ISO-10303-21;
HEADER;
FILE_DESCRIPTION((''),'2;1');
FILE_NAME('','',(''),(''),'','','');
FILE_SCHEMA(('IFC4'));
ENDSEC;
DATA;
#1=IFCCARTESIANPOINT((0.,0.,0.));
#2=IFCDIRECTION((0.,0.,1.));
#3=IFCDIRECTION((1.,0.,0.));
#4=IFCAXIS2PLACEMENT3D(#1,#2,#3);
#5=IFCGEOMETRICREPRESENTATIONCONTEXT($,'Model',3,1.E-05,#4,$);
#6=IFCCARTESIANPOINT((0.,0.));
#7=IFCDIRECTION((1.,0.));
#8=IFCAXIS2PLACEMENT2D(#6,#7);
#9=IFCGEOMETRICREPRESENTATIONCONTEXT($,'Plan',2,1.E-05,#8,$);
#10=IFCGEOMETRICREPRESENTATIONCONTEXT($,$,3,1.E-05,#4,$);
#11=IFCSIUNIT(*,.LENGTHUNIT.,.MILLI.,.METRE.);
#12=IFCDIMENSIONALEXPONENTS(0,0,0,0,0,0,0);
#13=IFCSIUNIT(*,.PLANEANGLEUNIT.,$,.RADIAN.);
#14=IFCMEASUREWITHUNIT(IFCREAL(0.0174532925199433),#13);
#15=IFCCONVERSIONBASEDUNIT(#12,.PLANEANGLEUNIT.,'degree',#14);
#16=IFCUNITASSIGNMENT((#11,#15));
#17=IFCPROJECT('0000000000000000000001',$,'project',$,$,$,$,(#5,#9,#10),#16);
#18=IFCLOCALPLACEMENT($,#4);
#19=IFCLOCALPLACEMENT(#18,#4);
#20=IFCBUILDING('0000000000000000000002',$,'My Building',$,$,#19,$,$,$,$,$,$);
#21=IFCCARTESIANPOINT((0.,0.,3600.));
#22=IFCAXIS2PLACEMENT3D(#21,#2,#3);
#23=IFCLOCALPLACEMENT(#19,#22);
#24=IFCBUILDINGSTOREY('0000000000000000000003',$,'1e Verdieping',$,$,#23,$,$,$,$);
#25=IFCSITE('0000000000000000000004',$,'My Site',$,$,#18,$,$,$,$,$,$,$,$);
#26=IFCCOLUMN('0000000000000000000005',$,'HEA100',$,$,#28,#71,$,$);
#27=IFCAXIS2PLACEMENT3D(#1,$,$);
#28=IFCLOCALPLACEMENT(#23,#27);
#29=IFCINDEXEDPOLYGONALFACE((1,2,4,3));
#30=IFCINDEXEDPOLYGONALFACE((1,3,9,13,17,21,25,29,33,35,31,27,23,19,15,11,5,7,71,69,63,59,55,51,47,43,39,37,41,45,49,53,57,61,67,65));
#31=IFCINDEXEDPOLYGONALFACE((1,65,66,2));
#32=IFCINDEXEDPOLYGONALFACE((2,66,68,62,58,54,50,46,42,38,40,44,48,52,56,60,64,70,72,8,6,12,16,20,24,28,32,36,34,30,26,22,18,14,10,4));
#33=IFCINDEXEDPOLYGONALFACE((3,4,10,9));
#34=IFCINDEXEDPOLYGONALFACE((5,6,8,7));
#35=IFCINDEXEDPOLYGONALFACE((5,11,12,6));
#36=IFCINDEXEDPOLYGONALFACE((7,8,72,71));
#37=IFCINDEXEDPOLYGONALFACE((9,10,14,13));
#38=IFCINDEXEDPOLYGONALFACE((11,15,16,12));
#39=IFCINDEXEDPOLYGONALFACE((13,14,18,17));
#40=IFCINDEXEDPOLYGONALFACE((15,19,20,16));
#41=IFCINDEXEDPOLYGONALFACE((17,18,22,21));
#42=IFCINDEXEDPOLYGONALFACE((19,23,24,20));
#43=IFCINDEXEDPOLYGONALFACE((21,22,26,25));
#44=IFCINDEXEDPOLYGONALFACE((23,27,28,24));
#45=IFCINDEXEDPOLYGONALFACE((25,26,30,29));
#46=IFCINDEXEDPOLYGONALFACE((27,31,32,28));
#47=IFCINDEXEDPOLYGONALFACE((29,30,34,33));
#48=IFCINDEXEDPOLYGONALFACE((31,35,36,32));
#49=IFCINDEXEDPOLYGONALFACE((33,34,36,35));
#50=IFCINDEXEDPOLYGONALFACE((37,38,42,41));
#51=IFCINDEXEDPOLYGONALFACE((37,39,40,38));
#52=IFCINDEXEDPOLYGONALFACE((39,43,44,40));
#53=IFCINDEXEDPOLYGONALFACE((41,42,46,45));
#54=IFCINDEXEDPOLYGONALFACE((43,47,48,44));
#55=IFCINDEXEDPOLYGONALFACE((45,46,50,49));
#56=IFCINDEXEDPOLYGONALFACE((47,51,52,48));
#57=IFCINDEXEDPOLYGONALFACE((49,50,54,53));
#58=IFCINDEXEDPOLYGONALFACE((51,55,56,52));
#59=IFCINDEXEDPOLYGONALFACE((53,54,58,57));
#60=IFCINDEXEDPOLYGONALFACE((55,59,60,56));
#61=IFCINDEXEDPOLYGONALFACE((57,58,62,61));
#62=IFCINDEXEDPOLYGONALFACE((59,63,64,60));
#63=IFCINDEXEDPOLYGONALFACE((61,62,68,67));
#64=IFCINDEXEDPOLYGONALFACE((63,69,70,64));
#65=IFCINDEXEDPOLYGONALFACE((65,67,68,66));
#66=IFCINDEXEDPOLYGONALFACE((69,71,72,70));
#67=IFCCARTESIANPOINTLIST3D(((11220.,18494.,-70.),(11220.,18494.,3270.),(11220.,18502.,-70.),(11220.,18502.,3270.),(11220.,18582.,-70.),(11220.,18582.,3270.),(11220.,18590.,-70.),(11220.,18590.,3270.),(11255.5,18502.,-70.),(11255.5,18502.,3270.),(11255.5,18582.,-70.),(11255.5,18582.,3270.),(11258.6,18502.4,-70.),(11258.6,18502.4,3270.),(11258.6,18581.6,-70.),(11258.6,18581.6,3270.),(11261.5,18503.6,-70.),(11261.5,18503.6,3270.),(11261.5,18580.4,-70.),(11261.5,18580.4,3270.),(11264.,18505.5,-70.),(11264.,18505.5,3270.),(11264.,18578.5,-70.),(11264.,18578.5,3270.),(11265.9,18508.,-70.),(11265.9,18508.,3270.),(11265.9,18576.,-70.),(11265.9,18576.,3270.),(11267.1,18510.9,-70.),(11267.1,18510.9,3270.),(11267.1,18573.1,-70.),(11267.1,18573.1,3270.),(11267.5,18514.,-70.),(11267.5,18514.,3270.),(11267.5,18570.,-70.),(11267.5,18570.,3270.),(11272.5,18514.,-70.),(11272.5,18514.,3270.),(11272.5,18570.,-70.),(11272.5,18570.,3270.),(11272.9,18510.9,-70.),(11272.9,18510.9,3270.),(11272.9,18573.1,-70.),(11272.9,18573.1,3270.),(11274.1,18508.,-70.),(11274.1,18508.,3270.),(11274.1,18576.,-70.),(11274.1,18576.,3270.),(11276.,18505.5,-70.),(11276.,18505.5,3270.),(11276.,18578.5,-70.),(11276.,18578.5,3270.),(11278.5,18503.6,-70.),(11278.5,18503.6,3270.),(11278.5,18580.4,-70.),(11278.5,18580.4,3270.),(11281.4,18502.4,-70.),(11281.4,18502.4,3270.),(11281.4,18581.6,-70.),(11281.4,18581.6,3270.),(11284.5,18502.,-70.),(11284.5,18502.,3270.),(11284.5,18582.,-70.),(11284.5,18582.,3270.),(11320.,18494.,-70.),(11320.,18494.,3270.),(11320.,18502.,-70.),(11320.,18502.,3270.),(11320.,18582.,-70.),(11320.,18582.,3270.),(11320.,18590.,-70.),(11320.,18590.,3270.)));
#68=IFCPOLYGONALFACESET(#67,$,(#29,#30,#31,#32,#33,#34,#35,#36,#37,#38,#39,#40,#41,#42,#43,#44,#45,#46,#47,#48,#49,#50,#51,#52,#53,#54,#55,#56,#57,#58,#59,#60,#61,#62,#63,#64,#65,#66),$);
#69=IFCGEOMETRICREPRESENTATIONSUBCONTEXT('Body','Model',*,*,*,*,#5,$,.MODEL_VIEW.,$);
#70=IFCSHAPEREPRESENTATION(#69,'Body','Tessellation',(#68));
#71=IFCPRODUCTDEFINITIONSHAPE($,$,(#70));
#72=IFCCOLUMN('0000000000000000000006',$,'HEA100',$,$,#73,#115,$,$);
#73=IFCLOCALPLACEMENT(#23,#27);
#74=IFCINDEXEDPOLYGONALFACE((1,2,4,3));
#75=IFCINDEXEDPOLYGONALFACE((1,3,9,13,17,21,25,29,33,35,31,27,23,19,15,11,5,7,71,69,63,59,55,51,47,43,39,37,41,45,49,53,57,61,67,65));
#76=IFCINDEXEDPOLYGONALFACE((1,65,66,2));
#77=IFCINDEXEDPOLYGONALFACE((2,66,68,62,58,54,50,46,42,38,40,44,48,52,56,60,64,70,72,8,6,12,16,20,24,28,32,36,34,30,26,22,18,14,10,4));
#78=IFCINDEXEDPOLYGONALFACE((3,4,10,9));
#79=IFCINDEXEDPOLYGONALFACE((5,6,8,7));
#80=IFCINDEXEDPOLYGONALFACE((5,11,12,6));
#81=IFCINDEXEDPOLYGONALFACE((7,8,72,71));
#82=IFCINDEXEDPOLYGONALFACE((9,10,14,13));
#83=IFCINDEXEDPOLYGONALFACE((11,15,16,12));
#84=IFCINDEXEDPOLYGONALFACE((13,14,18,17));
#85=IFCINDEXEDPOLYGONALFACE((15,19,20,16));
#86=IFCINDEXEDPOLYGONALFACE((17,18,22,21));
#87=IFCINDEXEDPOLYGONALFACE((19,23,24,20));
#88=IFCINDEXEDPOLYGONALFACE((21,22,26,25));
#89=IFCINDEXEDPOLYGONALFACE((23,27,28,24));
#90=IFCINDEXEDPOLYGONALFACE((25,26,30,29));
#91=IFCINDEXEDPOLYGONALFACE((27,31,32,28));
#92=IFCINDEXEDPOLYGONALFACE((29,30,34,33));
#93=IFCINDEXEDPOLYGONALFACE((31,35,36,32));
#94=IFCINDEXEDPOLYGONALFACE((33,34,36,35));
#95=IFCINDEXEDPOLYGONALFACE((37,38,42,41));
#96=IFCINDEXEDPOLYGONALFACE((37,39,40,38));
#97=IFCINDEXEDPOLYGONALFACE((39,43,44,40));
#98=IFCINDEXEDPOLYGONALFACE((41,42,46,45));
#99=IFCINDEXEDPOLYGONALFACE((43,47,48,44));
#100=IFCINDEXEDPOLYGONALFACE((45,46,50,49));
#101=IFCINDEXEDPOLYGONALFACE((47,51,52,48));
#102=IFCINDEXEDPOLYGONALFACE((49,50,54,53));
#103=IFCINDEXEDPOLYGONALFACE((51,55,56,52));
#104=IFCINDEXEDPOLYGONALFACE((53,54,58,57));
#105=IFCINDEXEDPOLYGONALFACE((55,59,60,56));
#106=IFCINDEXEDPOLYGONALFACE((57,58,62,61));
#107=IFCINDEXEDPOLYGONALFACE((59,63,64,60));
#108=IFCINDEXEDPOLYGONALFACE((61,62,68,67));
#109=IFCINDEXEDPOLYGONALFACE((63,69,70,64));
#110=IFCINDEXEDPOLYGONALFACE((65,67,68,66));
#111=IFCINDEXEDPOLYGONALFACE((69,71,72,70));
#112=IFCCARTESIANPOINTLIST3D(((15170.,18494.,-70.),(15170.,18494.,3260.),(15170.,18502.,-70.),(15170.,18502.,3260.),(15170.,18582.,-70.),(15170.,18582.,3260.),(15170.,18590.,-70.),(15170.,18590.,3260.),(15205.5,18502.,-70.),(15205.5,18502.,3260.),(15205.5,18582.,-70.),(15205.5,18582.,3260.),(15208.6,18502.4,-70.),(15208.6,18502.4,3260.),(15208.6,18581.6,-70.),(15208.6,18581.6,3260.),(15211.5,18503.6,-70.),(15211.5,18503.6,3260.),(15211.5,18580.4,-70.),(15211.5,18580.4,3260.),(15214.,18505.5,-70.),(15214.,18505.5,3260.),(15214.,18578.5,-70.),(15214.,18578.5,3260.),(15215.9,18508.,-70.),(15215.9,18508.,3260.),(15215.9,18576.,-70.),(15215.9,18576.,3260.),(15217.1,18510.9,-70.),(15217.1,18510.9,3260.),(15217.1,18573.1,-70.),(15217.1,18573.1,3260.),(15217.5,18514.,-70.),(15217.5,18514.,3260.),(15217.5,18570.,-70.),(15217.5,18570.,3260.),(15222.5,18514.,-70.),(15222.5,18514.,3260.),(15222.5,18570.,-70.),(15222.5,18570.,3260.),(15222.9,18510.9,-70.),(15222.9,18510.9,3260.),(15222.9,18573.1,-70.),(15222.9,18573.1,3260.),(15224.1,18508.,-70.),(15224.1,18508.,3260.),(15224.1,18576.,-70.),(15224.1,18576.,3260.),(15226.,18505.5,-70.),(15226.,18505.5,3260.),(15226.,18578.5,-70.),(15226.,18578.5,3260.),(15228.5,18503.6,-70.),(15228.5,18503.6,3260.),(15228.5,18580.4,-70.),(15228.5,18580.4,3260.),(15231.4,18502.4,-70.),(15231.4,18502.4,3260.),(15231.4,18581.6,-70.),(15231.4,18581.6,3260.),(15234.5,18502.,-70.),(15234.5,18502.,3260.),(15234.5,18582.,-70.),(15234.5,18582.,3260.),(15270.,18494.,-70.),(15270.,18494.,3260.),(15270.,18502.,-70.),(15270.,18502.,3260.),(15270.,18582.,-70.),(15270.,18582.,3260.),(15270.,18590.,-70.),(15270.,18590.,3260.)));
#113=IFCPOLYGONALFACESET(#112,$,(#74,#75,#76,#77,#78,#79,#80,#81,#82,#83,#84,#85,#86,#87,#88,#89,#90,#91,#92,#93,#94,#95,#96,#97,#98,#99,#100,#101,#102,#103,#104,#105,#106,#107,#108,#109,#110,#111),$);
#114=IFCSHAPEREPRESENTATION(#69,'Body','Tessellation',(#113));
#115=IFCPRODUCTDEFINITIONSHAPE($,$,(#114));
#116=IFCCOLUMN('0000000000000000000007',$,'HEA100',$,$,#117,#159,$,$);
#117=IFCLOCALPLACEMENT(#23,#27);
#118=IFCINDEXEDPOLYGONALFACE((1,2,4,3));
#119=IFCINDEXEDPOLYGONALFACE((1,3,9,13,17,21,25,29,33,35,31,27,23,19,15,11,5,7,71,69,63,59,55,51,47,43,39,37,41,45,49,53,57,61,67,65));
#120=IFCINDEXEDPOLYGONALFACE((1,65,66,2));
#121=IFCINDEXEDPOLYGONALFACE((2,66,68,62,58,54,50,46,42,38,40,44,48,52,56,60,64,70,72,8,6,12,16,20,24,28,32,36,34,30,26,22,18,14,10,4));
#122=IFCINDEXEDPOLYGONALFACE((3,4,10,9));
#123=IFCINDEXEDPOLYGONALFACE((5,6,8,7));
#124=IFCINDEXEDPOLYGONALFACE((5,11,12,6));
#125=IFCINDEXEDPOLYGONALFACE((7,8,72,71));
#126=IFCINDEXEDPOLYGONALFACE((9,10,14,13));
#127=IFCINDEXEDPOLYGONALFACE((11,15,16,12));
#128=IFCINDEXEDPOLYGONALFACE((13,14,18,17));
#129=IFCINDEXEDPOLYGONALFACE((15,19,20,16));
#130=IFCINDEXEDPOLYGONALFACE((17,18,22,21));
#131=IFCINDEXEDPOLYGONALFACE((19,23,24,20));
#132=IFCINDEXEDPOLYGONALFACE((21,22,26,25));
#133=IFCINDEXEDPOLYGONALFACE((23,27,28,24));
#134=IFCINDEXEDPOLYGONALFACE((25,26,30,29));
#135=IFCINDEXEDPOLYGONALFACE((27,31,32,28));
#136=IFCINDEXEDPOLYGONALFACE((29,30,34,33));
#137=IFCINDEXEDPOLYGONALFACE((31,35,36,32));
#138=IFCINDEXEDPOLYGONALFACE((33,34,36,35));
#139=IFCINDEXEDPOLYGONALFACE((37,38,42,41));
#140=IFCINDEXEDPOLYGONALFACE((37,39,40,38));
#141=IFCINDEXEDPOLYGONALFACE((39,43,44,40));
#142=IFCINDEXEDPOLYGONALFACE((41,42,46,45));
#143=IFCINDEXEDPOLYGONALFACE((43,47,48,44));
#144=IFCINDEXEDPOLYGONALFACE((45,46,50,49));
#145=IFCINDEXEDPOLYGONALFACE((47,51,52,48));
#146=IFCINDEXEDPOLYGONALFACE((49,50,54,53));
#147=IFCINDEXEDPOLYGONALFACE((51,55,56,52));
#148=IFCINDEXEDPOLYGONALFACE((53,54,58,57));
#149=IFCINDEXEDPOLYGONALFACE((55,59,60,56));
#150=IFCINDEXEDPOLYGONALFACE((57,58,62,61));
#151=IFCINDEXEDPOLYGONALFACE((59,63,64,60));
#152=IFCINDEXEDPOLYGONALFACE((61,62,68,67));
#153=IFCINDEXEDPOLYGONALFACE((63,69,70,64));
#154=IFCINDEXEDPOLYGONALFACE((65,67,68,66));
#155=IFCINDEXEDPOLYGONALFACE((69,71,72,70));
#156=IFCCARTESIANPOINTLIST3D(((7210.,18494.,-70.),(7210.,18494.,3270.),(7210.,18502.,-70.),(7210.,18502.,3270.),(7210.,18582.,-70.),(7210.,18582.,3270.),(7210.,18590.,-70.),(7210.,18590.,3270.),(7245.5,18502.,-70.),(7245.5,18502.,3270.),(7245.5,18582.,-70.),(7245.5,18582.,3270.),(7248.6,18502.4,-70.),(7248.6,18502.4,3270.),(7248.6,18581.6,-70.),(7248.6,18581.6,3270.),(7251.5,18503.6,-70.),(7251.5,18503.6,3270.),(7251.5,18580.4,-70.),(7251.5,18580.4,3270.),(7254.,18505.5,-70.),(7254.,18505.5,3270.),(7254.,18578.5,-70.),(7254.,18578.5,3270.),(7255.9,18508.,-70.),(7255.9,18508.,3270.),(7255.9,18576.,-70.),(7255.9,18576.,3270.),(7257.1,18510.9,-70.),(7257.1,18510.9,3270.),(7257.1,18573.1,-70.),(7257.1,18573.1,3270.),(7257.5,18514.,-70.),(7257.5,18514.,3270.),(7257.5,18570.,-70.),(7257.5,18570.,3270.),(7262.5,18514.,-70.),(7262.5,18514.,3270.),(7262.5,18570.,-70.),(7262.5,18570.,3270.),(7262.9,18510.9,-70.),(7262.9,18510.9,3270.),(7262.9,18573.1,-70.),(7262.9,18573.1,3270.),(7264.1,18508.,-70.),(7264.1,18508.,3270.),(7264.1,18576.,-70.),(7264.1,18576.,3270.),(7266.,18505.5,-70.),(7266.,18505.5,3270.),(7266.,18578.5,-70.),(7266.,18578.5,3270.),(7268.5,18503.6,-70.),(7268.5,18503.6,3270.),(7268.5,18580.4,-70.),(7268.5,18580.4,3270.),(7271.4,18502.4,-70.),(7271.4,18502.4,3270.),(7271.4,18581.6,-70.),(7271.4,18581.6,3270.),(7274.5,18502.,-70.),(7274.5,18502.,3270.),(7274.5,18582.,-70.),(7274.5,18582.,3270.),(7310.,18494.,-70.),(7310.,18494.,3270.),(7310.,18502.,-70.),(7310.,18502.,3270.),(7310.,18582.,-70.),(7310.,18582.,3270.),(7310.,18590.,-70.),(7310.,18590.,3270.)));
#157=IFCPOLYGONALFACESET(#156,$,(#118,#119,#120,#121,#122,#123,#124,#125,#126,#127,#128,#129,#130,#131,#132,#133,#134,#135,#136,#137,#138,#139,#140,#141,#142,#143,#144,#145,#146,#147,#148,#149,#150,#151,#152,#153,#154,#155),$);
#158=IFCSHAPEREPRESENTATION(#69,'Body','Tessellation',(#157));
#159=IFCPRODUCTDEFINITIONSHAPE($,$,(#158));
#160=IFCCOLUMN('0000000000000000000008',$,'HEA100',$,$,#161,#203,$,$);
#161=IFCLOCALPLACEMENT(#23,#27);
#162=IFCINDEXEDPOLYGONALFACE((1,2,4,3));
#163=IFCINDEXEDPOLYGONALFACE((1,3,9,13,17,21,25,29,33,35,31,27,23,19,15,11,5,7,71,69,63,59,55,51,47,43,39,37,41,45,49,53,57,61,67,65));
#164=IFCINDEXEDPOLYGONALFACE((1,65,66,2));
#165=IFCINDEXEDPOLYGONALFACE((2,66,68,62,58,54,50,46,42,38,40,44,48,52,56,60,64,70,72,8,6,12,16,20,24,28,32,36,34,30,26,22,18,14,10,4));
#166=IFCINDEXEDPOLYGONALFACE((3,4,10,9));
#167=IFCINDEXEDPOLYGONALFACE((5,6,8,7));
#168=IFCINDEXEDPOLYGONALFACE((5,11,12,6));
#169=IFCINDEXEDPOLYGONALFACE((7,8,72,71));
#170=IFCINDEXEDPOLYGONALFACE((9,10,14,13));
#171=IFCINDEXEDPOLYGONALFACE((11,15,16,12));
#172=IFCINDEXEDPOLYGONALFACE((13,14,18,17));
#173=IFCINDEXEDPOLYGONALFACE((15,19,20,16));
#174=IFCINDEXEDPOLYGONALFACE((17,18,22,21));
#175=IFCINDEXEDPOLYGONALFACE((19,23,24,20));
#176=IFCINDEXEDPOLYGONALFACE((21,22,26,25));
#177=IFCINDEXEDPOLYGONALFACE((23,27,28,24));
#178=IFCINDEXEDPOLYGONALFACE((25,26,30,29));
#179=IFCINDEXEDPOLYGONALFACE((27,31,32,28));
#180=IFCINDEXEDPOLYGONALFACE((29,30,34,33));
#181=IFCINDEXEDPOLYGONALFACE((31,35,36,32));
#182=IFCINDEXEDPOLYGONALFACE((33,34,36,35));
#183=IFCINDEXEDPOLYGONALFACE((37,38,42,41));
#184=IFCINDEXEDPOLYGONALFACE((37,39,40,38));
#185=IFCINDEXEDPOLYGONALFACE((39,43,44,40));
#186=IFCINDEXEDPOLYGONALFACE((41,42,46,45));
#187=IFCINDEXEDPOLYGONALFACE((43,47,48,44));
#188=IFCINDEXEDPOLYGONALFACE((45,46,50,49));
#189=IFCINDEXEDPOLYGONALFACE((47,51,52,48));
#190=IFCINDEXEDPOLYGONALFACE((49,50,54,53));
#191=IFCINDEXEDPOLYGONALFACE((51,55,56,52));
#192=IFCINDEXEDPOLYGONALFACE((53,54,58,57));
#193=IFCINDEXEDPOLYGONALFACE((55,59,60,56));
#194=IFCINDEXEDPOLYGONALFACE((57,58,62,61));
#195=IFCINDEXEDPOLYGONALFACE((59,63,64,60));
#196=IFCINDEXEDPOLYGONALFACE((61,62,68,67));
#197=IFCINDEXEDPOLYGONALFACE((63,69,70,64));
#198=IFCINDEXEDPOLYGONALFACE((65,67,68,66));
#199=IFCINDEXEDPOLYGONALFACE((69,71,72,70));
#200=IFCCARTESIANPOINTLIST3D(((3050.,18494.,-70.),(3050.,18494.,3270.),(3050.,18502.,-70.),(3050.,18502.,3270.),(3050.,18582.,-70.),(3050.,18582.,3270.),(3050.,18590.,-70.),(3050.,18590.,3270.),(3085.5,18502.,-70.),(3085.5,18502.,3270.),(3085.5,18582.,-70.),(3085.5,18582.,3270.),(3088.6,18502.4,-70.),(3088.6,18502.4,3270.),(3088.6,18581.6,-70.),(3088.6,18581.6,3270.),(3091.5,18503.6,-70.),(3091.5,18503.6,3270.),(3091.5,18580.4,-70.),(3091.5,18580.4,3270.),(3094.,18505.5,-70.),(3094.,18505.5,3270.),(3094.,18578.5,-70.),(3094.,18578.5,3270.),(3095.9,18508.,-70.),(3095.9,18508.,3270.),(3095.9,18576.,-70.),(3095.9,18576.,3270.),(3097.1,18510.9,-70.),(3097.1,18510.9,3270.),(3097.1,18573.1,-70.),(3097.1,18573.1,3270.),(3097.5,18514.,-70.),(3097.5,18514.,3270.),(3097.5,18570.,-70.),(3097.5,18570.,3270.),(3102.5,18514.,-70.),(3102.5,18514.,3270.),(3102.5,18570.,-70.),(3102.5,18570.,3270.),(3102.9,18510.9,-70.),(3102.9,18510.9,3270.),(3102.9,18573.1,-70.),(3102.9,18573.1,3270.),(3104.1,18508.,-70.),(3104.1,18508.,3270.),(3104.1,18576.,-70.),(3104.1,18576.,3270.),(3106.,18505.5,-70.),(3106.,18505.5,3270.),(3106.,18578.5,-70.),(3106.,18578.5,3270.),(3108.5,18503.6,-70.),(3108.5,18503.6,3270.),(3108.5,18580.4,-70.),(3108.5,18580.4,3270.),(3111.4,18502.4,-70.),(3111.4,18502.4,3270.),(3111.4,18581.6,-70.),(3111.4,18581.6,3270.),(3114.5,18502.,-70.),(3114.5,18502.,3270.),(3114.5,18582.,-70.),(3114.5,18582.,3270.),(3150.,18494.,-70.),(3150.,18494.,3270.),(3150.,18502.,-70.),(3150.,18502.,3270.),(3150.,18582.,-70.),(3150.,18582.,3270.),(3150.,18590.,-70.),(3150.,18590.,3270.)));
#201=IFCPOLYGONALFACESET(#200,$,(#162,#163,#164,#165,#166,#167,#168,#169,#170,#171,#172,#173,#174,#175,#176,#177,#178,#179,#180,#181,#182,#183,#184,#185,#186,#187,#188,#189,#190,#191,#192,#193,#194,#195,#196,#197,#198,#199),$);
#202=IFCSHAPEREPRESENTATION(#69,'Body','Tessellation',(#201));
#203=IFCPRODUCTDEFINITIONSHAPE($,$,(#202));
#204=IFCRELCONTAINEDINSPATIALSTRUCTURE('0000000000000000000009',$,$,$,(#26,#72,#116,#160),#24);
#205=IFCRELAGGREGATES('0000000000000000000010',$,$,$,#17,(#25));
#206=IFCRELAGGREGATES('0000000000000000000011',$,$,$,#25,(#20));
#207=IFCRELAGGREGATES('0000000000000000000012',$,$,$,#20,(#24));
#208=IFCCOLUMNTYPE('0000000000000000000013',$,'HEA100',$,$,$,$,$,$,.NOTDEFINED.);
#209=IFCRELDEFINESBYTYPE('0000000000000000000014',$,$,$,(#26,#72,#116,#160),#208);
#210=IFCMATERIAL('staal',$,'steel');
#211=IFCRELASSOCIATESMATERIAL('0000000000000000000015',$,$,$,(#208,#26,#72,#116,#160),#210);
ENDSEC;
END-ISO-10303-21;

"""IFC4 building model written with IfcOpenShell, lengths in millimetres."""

from ifc_helpers import new_model, entity, si_unit, converted_unit, frame, origin_with_axes, origin_2d_with_axis, place, context, subcontext, project, spatial, i_section, extrude, material, material_profile, profile_set, profile_usage, type_object, element, save


model = new_model("IFC4")

# Units and contexts
model_context = context("Model", 3, precision=1e-05, world=origin_with_axes())
plan_context = context("Plan", 2, precision=1e-05, world=origin_2d_with_axis())
context_of_model = context(None, 3, precision=1e-05, world=origin_with_axes())
body_context = subcontext(model_context, "Body", "Model", "MODEL_VIEW")
ifc_project = project(units=[si_unit("LENGTHUNIT", "METRE", prefix="MILLI"), converted_unit("PLANEANGLEUNIT", "degree", entity("IfcReal", 0.0174532925199433), si_unit("PLANEANGLEUNIT", "RADIAN"), dimensions=[0, 0, 0, 0, 0, 0, 0])], contexts=[model_context, plan_context, context_of_model])

# Site, building, storey
site_placement = place(None, origin_with_axes())
site = spatial("IfcSite", under=ifc_project, at=site_placement, Name="My Site")
building_placement = place(site_placement, origin_with_axes())
building = spatial("IfcBuilding", under=site, at=building_placement, Name="My Building")
storey_placement = place(building_placement, frame((0.0, 0.0, 3600.0), z_axis=(0.0, 0.0, 1.0), x_axis=(1.0, 0.0, 0.0)))
storey = spatial("IfcBuildingStorey", under=building, at=storey_placement, Name="1e Verdieping")

# Columns
ifc_material_1 = material(Name="staal", Category="steel")
ifc_material_profile_1 = material_profile(ifc_material_1, i_section(OverallWidth=100.0, OverallDepth=96.0, WebThickness=5.0, FlangeThickness=8.0, FilletRadius=12.0))
ifc_profile_set_1 = profile_set([ifc_material_profile_1], Name="HEA100")
column_type_1 = type_object("IfcColumnType", Name="HEA100", PredefinedType="NOTDEFINED", material=ifc_profile_set_1)
ifc_profile_usage_1 = profile_usage(ifc_profile_set_1)
column_1_placement = place(storey_placement, frame((11270.0, 18542.0, -70.0), z_axis=(0.0, 0.0, 1.0), x_axis=(1.0, 0.0, 0.0)))
element("IfcColumn", 1, at=column_1_placement, inside=storey, type_object=column_type_1, material=ifc_profile_usage_1, Name="HEA100", context=body_context, shape_type="SweptSolid", body=[
    extrude(i_section(OverallWidth=100.0, OverallDepth=96.0, WebThickness=5.0, FlangeThickness=8.0, FilletRadius=12.0), origin_with_axes(), (0.0, 0.0, 1.0), 3340.0),
])
ifc_profile_usage_2 = profile_usage(ifc_profile_set_1)
column_2_placement = place(storey_placement, frame((15220.0, 18542.0, -70.0), z_axis=(0.0, 0.0, 1.0), x_axis=(1.0, 0.0, 0.0)))
element("IfcColumn", 2, at=column_2_placement, inside=storey, type_object=column_type_1, material=ifc_profile_usage_2, Name="HEA100", context=body_context, shape_type="SweptSolid", body=[
    extrude(i_section(OverallWidth=100.0, OverallDepth=96.0, WebThickness=5.0, FlangeThickness=8.0, FilletRadius=12.0), origin_with_axes(), (0.0, 0.0, 1.0), 3330.0),
])
ifc_profile_usage_3 = profile_usage(ifc_profile_set_1)
column_3_placement = place(storey_placement, frame((7260.0, 18542.0, -70.0), z_axis=(0.0, 0.0, 1.0), x_axis=(1.0, 0.0, 0.0)))
element("IfcColumn", 3, at=column_3_placement, inside=storey, type_object=column_type_1, material=ifc_profile_usage_3, Name="HEA100", context=body_context, shape_type="SweptSolid", body=[
    extrude(i_section(OverallWidth=100.0, OverallDepth=96.0, WebThickness=5.0, FlangeThickness=8.0, FilletRadius=12.0), origin_with_axes(), (0.0, 0.0, 1.0), 3340.0),
])
ifc_profile_usage_4 = profile_usage(ifc_profile_set_1)
column_4_placement = place(storey_placement, frame((3100.0, 18542.0, -70.0), z_axis=(0.0, 0.0, 1.0), x_axis=(1.0, 0.0, 0.0)))
element("IfcColumn", 4, at=column_4_placement, inside=storey, type_object=column_type_1, material=ifc_profile_usage_4, Name="HEA100", context=body_context, shape_type="SweptSolid", body=[
    extrude(i_section(OverallWidth=100.0, OverallDepth=96.0, WebThickness=5.0, FlangeThickness=8.0, FilletRadius=12.0), origin_with_axes(), (0.0, 0.0, 1.0), 3340.0),
])

save(model, "model.ifc")
